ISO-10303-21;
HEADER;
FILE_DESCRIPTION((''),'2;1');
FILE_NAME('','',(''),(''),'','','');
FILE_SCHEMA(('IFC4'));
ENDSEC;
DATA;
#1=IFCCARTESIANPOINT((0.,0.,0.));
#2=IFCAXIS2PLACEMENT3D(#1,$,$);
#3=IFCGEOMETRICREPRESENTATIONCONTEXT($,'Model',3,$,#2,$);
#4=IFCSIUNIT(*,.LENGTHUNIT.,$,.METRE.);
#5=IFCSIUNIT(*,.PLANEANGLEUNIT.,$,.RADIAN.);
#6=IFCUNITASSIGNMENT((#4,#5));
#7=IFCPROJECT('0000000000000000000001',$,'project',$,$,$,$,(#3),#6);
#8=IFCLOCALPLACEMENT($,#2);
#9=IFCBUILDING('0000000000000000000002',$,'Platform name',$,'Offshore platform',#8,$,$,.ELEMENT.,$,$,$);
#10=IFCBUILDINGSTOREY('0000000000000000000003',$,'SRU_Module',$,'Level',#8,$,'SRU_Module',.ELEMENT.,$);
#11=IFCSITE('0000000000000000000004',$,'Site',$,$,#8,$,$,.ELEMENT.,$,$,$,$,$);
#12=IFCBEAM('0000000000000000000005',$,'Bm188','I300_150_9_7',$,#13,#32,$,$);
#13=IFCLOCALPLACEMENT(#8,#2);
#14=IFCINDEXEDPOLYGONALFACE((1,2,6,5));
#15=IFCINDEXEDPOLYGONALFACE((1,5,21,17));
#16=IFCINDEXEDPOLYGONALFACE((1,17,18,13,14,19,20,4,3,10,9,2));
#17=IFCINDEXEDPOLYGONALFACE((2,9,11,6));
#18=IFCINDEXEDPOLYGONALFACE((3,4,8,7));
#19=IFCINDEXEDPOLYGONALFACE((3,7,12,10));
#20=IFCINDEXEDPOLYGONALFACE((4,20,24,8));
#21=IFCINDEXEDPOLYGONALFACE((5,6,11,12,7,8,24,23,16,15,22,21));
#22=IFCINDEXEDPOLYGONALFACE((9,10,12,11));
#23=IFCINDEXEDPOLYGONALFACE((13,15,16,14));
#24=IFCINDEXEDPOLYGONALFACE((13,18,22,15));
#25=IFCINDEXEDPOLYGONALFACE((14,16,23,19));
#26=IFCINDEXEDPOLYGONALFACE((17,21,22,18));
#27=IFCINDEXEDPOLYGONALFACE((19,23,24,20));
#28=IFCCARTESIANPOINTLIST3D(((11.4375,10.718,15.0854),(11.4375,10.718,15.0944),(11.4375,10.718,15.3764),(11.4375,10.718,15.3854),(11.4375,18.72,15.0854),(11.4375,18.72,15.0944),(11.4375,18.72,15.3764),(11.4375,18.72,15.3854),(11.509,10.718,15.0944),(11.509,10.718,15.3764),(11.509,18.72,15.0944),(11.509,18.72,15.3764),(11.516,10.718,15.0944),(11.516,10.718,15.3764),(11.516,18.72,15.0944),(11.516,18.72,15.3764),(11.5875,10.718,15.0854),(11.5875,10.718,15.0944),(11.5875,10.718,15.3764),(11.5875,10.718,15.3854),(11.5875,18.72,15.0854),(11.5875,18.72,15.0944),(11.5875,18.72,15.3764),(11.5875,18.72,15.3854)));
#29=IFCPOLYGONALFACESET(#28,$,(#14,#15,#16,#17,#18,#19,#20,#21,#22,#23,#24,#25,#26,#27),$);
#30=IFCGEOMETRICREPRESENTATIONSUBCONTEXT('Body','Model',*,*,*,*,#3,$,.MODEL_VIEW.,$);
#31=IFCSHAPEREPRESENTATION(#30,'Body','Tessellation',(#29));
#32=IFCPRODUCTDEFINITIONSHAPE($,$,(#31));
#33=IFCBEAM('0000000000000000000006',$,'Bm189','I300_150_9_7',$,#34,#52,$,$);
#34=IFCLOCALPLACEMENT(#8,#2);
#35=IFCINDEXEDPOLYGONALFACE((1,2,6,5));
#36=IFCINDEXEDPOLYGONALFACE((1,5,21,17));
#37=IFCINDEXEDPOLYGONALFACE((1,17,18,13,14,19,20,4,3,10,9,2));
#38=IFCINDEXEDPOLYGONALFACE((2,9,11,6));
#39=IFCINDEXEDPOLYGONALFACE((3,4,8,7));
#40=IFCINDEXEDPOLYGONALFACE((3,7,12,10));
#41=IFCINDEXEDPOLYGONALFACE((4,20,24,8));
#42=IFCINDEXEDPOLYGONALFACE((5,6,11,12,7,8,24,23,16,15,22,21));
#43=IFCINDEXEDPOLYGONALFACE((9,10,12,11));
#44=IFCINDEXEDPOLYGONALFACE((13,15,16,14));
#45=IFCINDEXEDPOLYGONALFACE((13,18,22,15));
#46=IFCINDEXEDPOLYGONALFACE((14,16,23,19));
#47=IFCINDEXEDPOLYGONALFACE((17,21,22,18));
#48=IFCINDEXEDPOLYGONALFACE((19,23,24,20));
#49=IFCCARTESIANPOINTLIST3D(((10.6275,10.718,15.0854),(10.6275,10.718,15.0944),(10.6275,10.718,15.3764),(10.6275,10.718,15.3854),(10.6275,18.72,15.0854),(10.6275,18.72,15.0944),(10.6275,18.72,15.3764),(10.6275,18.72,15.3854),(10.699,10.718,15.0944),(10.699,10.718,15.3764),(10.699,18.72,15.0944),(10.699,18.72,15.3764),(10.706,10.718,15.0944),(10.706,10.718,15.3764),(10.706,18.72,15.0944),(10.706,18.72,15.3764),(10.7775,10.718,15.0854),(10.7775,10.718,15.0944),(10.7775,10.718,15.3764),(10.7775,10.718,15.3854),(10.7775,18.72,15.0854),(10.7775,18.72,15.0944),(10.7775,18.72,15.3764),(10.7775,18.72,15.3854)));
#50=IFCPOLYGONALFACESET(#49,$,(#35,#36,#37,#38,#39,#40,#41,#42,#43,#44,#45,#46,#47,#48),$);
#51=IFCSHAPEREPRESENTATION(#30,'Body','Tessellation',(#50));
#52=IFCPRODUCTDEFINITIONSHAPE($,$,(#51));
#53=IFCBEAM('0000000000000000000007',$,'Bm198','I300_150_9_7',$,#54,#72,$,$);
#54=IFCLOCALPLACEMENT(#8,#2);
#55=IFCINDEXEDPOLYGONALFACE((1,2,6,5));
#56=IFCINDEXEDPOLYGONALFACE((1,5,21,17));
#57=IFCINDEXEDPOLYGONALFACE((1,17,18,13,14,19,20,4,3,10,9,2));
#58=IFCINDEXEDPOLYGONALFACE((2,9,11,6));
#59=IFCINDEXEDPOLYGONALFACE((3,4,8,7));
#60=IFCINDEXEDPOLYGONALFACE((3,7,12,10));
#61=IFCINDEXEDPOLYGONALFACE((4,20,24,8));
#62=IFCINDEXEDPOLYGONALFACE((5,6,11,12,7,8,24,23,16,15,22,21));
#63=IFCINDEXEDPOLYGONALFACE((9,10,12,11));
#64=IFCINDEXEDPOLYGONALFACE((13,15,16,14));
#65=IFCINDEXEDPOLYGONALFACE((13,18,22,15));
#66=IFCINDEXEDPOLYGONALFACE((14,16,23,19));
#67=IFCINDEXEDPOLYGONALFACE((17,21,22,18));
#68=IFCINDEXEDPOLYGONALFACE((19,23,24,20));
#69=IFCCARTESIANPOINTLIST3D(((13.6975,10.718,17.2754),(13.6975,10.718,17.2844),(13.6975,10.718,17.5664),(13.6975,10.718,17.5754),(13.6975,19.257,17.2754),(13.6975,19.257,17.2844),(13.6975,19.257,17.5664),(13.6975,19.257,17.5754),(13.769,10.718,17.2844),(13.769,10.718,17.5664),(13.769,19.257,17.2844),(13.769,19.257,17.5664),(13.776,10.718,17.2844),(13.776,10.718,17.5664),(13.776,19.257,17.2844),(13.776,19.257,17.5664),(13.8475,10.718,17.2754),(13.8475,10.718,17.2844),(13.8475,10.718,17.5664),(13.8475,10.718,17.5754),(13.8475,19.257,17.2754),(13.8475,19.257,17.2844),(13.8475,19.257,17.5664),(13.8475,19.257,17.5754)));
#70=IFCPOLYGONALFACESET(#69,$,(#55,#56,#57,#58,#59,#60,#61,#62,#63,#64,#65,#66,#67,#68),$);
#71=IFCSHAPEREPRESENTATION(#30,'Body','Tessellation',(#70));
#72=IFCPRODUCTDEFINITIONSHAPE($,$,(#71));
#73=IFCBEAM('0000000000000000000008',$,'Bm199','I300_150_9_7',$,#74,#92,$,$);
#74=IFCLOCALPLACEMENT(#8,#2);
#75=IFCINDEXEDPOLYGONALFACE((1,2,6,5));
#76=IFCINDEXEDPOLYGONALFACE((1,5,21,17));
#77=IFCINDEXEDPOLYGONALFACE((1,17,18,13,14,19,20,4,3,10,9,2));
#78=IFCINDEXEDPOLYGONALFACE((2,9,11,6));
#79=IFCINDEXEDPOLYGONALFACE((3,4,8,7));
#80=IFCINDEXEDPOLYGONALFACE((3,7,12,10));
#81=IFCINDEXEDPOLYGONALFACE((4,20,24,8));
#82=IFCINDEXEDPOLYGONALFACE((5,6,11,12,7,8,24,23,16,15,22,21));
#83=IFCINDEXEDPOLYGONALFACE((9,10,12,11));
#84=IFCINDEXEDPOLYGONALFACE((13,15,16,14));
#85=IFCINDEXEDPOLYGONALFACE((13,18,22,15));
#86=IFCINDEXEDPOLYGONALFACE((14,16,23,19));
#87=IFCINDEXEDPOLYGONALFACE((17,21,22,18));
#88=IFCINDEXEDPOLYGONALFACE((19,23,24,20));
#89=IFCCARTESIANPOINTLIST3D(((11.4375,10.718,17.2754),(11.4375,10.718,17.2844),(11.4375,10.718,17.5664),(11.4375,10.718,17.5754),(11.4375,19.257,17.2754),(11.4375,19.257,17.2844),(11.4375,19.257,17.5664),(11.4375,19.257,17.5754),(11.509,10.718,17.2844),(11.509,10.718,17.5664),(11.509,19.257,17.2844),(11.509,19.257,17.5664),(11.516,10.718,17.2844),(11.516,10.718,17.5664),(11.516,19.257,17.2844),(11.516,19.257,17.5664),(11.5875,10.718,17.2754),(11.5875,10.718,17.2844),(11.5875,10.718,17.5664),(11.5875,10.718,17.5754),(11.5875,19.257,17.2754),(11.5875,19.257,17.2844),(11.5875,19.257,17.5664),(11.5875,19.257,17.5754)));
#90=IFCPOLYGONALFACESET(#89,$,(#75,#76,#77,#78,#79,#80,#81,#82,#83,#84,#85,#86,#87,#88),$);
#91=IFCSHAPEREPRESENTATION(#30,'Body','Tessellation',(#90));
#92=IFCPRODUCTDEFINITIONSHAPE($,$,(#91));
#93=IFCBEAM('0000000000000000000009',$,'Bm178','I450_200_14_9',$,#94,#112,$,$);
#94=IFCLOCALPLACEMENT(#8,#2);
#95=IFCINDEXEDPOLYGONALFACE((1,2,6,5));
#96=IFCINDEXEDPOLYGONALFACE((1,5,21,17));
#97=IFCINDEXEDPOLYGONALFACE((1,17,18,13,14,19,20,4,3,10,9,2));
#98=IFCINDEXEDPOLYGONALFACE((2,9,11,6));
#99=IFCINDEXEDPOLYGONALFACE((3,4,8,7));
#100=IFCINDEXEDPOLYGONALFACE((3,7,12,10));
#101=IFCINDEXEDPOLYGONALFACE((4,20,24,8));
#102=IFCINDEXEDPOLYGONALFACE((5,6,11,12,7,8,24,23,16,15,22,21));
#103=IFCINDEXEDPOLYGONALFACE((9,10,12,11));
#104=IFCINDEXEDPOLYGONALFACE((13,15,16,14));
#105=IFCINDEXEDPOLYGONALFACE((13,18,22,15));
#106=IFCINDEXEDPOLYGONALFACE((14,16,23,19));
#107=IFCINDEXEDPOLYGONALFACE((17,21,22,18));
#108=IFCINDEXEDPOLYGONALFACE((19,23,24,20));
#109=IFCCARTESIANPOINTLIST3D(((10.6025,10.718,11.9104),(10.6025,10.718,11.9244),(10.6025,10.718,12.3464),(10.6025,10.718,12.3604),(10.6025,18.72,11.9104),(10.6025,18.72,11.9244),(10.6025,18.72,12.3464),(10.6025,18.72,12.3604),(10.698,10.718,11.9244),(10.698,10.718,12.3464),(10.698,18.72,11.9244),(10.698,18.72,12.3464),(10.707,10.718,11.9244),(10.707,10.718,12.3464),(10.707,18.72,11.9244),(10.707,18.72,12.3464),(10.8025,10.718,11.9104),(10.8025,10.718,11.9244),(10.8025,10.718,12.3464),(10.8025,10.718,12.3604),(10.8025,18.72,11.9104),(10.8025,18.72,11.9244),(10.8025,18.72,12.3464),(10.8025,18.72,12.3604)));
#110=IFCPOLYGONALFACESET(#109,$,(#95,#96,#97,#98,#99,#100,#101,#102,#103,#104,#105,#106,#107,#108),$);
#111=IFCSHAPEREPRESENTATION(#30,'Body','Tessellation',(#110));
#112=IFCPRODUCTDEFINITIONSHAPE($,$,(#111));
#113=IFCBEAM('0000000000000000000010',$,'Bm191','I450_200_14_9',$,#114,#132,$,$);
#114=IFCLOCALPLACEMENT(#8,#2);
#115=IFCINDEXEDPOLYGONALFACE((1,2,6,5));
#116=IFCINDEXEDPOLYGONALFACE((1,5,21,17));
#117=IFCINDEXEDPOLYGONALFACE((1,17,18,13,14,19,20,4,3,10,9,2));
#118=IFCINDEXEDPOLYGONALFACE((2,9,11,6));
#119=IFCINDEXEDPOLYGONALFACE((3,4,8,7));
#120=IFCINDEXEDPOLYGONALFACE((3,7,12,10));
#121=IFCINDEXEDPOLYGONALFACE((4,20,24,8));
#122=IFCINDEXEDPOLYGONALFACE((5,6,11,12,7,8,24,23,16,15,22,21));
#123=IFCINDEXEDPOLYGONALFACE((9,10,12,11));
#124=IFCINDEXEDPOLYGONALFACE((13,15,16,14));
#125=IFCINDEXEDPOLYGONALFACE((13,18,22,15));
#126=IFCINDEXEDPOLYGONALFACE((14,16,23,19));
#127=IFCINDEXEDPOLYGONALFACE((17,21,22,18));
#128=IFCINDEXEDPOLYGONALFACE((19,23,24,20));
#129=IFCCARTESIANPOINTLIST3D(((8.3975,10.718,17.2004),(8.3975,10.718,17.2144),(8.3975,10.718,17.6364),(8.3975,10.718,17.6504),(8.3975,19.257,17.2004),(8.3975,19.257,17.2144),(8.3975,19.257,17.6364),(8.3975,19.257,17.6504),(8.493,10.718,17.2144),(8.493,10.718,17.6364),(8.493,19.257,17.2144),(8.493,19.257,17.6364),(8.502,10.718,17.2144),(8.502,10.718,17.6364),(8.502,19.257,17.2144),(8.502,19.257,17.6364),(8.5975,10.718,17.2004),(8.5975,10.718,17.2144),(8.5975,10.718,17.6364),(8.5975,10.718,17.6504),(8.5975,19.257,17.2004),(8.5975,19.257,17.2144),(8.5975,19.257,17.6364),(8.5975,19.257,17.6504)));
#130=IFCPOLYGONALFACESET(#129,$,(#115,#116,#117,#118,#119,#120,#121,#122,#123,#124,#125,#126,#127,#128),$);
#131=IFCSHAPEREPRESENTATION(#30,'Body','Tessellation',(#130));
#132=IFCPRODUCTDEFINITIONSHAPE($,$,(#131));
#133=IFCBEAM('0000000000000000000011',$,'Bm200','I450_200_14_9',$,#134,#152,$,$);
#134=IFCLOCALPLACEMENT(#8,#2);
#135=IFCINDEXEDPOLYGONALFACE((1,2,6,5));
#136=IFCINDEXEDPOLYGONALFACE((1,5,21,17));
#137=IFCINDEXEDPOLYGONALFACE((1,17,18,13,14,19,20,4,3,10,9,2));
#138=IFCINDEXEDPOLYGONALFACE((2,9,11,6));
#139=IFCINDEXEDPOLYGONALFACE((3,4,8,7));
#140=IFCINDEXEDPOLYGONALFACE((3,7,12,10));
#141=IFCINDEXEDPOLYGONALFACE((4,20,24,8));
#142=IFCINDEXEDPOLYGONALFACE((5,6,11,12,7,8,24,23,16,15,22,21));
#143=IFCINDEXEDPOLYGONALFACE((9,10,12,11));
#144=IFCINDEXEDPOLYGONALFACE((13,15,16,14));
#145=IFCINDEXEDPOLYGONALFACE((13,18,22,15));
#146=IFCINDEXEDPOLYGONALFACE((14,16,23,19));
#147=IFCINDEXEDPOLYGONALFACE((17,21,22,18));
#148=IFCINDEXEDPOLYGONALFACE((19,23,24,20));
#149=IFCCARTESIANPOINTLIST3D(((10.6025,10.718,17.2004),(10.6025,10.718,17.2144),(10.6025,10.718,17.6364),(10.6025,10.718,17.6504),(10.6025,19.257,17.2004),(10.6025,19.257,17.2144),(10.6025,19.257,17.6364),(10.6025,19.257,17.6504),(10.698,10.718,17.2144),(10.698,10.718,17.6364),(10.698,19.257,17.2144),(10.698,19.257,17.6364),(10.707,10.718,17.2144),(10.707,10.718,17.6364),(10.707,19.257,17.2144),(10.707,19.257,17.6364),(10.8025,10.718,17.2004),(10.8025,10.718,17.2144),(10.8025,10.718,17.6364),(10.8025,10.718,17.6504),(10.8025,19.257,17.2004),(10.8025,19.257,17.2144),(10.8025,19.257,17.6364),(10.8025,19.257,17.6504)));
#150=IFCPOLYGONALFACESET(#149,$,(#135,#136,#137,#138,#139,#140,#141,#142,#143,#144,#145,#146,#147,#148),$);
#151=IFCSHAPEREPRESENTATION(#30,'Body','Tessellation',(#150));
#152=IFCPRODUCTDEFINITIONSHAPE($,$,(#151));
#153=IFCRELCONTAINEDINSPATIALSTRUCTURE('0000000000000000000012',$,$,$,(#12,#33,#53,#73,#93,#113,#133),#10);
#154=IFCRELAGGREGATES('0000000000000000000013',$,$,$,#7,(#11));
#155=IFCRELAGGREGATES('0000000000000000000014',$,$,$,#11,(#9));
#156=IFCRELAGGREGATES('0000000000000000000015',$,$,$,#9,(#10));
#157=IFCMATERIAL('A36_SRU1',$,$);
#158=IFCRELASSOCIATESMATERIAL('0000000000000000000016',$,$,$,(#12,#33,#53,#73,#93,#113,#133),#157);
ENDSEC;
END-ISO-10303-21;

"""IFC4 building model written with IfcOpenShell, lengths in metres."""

from ifc_helpers import new_model, si_unit, frame, origin, origin_2d, place, context, subcontext, project, spatial, i_section, extrude, source, transform, mapped, material, element, save


model = new_model("IFC4")

# Units and contexts
model_context = context("Model", 3, world=origin())
body_context = subcontext(model_context, "Body", "Model", "MODEL_VIEW")
ifc_project = project(units=[si_unit("LENGTHUNIT", "METRE"), si_unit("PLANEANGLEUNIT", "RADIAN")], contexts=[model_context])

# Site, building, storey
placement_1 = place(None, origin())
site = spatial("IfcSite", under=ifc_project, at=placement_1, Name="Site", CompositionType="ELEMENT")
building = spatial("IfcBuilding", under=site, at=placement_1, Name="Platform name", ObjectType="Offshore platform", CompositionType="ELEMENT")
storey = spatial("IfcBuildingStorey", under=building, at=placement_1, Name="SRU_Module", ObjectType="Level", LongName="SRU_Module", CompositionType="ELEMENT")

# Beams
ifc_material = material(Name="A36_SRU1")
shared_shape_1 = source(origin(), body_context, "Body", "SweptSolid", [
    extrude(i_section(OverallWidth=0.15, OverallDepth=0.3, WebThickness=0.007, FlangeThickness=0.009, FilletRadius=0.0, at=origin_2d()), frame((0.0, 0.0, 0.0), z_axis=(0.0, 1.0, 0.0), x_axis=(-1.0, 0.0, 0.0)), (0.0, 0.0, 1.0), 8.002),
])
placement_2 = place(None, origin())
placement_3 = place(placement_2, origin())
placement_4 = place(placement_3, origin())
beam_1_placement = place(placement_4, frame((11.5125, 10.718, 15.2354)))
element("IfcBeam", 1, at=beam_1_placement, inside=storey, material=ifc_material, Name="Bm188", Description="I300_150_9_7", context=body_context, shape_type="MappedRepresentation", body=[
    mapped(shared_shape_1, transform((0.0, 0.0, 0.0), scale=1.0)),
])
shared_shape_2 = source(origin(), body_context, "Body", "SweptSolid", [
    extrude(i_section(OverallWidth=0.15, OverallDepth=0.3, WebThickness=0.007, FlangeThickness=0.009, FilletRadius=0.0, at=origin_2d()), frame((0.0, 0.0, 0.0), z_axis=(0.0, 1.0, 0.0), x_axis=(-1.0, 0.0, 0.0)), (0.0, 0.0, 1.0), 8.002),
])
placement_5 = place(None, origin())
placement_6 = place(placement_5, origin())
placement_7 = place(placement_6, origin())
beam_2_placement = place(placement_7, frame((10.7025, 10.718, 15.2354)))
element("IfcBeam", 2, at=beam_2_placement, inside=storey, material=ifc_material, Name="Bm189", Description="I300_150_9_7", context=body_context, shape_type="MappedRepresentation", body=[
    mapped(shared_shape_2, transform((0.0, 0.0, 0.0), scale=1.0)),
])
shared_shape_3 = source(origin(), body_context, "Body", "SweptSolid", [
    extrude(i_section(OverallWidth=0.15, OverallDepth=0.3, WebThickness=0.007, FlangeThickness=0.009, FilletRadius=0.0, at=origin_2d()), frame((0.0, 0.0, 0.0), z_axis=(0.0, 1.0, 0.0), x_axis=(-1.0, 0.0, 0.0)), (0.0, 0.0, 1.0), 8.539),
])
placement_8 = place(None, origin())
placement_9 = place(placement_8, origin())
placement_10 = place(placement_9, origin())
beam_3_placement = place(placement_10, frame((13.7725, 10.718, 17.4254)))
element("IfcBeam", 3, at=beam_3_placement, inside=storey, material=ifc_material, Name="Bm198", Description="I300_150_9_7", context=body_context, shape_type="MappedRepresentation", body=[
    mapped(shared_shape_3, transform((0.0, 0.0, 0.0), scale=1.0)),
])
shared_shape_4 = source(origin(), body_context, "Body", "SweptSolid", [
    extrude(i_section(OverallWidth=0.15, OverallDepth=0.3, WebThickness=0.007, FlangeThickness=0.009, FilletRadius=0.0, at=origin_2d()), frame((0.0, 0.0, 0.0), z_axis=(0.0, 1.0, 0.0), x_axis=(-1.0, 0.0, 0.0)), (0.0, 0.0, 1.0), 8.539),
])
placement_11 = place(None, origin())
placement_12 = place(placement_11, origin())
placement_13 = place(placement_12, origin())
beam_4_placement = place(placement_13, frame((11.5125, 10.718, 17.4254)))
element("IfcBeam", 4, at=beam_4_placement, inside=storey, material=ifc_material, Name="Bm199", Description="I300_150_9_7", context=body_context, shape_type="MappedRepresentation", body=[
    mapped(shared_shape_4, transform((0.0, 0.0, 0.0), scale=1.0)),
])
shared_shape_5 = source(origin(), body_context, "Body", "SweptSolid", [
    extrude(i_section(OverallWidth=0.2, OverallDepth=0.45, WebThickness=0.009, FlangeThickness=0.014, FilletRadius=0.0, at=origin_2d()), frame((0.0, 0.0, 0.0), z_axis=(0.0, 1.0, 0.0), x_axis=(-1.0, 0.0, 0.0)), (0.0, 0.0, 1.0), 8.002),
])
placement_14 = place(None, origin())
placement_15 = place(placement_14, origin())
placement_16 = place(placement_15, origin())
beam_5_placement = place(placement_16, frame((10.7025, 10.718, 12.1354)))
element("IfcBeam", 5, at=beam_5_placement, inside=storey, material=ifc_material, Name="Bm178", Description="I450_200_14_9", context=body_context, shape_type="MappedRepresentation", body=[
    mapped(shared_shape_5, transform((0.0, 0.0, 0.0), scale=1.0)),
])
shared_shape_6 = source(origin(), body_context, "Body", "SweptSolid", [
    extrude(i_section(OverallWidth=0.2, OverallDepth=0.45, WebThickness=0.009, FlangeThickness=0.014, FilletRadius=0.0, at=origin_2d()), frame((0.0, 0.0, 0.0), z_axis=(0.0, 1.0, 0.0), x_axis=(-1.0, 0.0, 0.0)), (0.0, 0.0, 1.0), 8.539),
])
placement_17 = place(None, origin())
placement_18 = place(placement_17, origin())
placement_19 = place(placement_18, origin())
beam_6_placement = place(placement_19, frame((8.4975, 10.718, 17.4254)))
element("IfcBeam", 6, at=beam_6_placement, inside=storey, material=ifc_material, Name="Bm191", Description="I450_200_14_9", context=body_context, shape_type="MappedRepresentation", body=[
    mapped(shared_shape_6, transform((0.0, 0.0, 0.0), scale=1.0)),
])
shared_shape_7 = source(origin(), body_context, "Body", "SweptSolid", [
    extrude(i_section(OverallWidth=0.2, OverallDepth=0.45, WebThickness=0.009, FlangeThickness=0.014, FilletRadius=0.0, at=origin_2d()), frame((0.0, 0.0, 0.0), z_axis=(0.0, 1.0, 0.0), x_axis=(-1.0, 0.0, 0.0)), (0.0, 0.0, 1.0), 8.539),
])
placement_20 = place(None, origin())
placement_21 = place(placement_20, origin())
placement_22 = place(placement_21, origin())
beam_7_placement = place(placement_22, frame((10.7025, 10.718, 17.4254)))
element("IfcBeam", 7, at=beam_7_placement, inside=storey, material=ifc_material, Name="Bm200", Description="I450_200_14_9", context=body_context, shape_type="MappedRepresentation", body=[
    mapped(shared_shape_7, transform((0.0, 0.0, 0.0), scale=1.0)),
])

save(model, "model.ifc")
